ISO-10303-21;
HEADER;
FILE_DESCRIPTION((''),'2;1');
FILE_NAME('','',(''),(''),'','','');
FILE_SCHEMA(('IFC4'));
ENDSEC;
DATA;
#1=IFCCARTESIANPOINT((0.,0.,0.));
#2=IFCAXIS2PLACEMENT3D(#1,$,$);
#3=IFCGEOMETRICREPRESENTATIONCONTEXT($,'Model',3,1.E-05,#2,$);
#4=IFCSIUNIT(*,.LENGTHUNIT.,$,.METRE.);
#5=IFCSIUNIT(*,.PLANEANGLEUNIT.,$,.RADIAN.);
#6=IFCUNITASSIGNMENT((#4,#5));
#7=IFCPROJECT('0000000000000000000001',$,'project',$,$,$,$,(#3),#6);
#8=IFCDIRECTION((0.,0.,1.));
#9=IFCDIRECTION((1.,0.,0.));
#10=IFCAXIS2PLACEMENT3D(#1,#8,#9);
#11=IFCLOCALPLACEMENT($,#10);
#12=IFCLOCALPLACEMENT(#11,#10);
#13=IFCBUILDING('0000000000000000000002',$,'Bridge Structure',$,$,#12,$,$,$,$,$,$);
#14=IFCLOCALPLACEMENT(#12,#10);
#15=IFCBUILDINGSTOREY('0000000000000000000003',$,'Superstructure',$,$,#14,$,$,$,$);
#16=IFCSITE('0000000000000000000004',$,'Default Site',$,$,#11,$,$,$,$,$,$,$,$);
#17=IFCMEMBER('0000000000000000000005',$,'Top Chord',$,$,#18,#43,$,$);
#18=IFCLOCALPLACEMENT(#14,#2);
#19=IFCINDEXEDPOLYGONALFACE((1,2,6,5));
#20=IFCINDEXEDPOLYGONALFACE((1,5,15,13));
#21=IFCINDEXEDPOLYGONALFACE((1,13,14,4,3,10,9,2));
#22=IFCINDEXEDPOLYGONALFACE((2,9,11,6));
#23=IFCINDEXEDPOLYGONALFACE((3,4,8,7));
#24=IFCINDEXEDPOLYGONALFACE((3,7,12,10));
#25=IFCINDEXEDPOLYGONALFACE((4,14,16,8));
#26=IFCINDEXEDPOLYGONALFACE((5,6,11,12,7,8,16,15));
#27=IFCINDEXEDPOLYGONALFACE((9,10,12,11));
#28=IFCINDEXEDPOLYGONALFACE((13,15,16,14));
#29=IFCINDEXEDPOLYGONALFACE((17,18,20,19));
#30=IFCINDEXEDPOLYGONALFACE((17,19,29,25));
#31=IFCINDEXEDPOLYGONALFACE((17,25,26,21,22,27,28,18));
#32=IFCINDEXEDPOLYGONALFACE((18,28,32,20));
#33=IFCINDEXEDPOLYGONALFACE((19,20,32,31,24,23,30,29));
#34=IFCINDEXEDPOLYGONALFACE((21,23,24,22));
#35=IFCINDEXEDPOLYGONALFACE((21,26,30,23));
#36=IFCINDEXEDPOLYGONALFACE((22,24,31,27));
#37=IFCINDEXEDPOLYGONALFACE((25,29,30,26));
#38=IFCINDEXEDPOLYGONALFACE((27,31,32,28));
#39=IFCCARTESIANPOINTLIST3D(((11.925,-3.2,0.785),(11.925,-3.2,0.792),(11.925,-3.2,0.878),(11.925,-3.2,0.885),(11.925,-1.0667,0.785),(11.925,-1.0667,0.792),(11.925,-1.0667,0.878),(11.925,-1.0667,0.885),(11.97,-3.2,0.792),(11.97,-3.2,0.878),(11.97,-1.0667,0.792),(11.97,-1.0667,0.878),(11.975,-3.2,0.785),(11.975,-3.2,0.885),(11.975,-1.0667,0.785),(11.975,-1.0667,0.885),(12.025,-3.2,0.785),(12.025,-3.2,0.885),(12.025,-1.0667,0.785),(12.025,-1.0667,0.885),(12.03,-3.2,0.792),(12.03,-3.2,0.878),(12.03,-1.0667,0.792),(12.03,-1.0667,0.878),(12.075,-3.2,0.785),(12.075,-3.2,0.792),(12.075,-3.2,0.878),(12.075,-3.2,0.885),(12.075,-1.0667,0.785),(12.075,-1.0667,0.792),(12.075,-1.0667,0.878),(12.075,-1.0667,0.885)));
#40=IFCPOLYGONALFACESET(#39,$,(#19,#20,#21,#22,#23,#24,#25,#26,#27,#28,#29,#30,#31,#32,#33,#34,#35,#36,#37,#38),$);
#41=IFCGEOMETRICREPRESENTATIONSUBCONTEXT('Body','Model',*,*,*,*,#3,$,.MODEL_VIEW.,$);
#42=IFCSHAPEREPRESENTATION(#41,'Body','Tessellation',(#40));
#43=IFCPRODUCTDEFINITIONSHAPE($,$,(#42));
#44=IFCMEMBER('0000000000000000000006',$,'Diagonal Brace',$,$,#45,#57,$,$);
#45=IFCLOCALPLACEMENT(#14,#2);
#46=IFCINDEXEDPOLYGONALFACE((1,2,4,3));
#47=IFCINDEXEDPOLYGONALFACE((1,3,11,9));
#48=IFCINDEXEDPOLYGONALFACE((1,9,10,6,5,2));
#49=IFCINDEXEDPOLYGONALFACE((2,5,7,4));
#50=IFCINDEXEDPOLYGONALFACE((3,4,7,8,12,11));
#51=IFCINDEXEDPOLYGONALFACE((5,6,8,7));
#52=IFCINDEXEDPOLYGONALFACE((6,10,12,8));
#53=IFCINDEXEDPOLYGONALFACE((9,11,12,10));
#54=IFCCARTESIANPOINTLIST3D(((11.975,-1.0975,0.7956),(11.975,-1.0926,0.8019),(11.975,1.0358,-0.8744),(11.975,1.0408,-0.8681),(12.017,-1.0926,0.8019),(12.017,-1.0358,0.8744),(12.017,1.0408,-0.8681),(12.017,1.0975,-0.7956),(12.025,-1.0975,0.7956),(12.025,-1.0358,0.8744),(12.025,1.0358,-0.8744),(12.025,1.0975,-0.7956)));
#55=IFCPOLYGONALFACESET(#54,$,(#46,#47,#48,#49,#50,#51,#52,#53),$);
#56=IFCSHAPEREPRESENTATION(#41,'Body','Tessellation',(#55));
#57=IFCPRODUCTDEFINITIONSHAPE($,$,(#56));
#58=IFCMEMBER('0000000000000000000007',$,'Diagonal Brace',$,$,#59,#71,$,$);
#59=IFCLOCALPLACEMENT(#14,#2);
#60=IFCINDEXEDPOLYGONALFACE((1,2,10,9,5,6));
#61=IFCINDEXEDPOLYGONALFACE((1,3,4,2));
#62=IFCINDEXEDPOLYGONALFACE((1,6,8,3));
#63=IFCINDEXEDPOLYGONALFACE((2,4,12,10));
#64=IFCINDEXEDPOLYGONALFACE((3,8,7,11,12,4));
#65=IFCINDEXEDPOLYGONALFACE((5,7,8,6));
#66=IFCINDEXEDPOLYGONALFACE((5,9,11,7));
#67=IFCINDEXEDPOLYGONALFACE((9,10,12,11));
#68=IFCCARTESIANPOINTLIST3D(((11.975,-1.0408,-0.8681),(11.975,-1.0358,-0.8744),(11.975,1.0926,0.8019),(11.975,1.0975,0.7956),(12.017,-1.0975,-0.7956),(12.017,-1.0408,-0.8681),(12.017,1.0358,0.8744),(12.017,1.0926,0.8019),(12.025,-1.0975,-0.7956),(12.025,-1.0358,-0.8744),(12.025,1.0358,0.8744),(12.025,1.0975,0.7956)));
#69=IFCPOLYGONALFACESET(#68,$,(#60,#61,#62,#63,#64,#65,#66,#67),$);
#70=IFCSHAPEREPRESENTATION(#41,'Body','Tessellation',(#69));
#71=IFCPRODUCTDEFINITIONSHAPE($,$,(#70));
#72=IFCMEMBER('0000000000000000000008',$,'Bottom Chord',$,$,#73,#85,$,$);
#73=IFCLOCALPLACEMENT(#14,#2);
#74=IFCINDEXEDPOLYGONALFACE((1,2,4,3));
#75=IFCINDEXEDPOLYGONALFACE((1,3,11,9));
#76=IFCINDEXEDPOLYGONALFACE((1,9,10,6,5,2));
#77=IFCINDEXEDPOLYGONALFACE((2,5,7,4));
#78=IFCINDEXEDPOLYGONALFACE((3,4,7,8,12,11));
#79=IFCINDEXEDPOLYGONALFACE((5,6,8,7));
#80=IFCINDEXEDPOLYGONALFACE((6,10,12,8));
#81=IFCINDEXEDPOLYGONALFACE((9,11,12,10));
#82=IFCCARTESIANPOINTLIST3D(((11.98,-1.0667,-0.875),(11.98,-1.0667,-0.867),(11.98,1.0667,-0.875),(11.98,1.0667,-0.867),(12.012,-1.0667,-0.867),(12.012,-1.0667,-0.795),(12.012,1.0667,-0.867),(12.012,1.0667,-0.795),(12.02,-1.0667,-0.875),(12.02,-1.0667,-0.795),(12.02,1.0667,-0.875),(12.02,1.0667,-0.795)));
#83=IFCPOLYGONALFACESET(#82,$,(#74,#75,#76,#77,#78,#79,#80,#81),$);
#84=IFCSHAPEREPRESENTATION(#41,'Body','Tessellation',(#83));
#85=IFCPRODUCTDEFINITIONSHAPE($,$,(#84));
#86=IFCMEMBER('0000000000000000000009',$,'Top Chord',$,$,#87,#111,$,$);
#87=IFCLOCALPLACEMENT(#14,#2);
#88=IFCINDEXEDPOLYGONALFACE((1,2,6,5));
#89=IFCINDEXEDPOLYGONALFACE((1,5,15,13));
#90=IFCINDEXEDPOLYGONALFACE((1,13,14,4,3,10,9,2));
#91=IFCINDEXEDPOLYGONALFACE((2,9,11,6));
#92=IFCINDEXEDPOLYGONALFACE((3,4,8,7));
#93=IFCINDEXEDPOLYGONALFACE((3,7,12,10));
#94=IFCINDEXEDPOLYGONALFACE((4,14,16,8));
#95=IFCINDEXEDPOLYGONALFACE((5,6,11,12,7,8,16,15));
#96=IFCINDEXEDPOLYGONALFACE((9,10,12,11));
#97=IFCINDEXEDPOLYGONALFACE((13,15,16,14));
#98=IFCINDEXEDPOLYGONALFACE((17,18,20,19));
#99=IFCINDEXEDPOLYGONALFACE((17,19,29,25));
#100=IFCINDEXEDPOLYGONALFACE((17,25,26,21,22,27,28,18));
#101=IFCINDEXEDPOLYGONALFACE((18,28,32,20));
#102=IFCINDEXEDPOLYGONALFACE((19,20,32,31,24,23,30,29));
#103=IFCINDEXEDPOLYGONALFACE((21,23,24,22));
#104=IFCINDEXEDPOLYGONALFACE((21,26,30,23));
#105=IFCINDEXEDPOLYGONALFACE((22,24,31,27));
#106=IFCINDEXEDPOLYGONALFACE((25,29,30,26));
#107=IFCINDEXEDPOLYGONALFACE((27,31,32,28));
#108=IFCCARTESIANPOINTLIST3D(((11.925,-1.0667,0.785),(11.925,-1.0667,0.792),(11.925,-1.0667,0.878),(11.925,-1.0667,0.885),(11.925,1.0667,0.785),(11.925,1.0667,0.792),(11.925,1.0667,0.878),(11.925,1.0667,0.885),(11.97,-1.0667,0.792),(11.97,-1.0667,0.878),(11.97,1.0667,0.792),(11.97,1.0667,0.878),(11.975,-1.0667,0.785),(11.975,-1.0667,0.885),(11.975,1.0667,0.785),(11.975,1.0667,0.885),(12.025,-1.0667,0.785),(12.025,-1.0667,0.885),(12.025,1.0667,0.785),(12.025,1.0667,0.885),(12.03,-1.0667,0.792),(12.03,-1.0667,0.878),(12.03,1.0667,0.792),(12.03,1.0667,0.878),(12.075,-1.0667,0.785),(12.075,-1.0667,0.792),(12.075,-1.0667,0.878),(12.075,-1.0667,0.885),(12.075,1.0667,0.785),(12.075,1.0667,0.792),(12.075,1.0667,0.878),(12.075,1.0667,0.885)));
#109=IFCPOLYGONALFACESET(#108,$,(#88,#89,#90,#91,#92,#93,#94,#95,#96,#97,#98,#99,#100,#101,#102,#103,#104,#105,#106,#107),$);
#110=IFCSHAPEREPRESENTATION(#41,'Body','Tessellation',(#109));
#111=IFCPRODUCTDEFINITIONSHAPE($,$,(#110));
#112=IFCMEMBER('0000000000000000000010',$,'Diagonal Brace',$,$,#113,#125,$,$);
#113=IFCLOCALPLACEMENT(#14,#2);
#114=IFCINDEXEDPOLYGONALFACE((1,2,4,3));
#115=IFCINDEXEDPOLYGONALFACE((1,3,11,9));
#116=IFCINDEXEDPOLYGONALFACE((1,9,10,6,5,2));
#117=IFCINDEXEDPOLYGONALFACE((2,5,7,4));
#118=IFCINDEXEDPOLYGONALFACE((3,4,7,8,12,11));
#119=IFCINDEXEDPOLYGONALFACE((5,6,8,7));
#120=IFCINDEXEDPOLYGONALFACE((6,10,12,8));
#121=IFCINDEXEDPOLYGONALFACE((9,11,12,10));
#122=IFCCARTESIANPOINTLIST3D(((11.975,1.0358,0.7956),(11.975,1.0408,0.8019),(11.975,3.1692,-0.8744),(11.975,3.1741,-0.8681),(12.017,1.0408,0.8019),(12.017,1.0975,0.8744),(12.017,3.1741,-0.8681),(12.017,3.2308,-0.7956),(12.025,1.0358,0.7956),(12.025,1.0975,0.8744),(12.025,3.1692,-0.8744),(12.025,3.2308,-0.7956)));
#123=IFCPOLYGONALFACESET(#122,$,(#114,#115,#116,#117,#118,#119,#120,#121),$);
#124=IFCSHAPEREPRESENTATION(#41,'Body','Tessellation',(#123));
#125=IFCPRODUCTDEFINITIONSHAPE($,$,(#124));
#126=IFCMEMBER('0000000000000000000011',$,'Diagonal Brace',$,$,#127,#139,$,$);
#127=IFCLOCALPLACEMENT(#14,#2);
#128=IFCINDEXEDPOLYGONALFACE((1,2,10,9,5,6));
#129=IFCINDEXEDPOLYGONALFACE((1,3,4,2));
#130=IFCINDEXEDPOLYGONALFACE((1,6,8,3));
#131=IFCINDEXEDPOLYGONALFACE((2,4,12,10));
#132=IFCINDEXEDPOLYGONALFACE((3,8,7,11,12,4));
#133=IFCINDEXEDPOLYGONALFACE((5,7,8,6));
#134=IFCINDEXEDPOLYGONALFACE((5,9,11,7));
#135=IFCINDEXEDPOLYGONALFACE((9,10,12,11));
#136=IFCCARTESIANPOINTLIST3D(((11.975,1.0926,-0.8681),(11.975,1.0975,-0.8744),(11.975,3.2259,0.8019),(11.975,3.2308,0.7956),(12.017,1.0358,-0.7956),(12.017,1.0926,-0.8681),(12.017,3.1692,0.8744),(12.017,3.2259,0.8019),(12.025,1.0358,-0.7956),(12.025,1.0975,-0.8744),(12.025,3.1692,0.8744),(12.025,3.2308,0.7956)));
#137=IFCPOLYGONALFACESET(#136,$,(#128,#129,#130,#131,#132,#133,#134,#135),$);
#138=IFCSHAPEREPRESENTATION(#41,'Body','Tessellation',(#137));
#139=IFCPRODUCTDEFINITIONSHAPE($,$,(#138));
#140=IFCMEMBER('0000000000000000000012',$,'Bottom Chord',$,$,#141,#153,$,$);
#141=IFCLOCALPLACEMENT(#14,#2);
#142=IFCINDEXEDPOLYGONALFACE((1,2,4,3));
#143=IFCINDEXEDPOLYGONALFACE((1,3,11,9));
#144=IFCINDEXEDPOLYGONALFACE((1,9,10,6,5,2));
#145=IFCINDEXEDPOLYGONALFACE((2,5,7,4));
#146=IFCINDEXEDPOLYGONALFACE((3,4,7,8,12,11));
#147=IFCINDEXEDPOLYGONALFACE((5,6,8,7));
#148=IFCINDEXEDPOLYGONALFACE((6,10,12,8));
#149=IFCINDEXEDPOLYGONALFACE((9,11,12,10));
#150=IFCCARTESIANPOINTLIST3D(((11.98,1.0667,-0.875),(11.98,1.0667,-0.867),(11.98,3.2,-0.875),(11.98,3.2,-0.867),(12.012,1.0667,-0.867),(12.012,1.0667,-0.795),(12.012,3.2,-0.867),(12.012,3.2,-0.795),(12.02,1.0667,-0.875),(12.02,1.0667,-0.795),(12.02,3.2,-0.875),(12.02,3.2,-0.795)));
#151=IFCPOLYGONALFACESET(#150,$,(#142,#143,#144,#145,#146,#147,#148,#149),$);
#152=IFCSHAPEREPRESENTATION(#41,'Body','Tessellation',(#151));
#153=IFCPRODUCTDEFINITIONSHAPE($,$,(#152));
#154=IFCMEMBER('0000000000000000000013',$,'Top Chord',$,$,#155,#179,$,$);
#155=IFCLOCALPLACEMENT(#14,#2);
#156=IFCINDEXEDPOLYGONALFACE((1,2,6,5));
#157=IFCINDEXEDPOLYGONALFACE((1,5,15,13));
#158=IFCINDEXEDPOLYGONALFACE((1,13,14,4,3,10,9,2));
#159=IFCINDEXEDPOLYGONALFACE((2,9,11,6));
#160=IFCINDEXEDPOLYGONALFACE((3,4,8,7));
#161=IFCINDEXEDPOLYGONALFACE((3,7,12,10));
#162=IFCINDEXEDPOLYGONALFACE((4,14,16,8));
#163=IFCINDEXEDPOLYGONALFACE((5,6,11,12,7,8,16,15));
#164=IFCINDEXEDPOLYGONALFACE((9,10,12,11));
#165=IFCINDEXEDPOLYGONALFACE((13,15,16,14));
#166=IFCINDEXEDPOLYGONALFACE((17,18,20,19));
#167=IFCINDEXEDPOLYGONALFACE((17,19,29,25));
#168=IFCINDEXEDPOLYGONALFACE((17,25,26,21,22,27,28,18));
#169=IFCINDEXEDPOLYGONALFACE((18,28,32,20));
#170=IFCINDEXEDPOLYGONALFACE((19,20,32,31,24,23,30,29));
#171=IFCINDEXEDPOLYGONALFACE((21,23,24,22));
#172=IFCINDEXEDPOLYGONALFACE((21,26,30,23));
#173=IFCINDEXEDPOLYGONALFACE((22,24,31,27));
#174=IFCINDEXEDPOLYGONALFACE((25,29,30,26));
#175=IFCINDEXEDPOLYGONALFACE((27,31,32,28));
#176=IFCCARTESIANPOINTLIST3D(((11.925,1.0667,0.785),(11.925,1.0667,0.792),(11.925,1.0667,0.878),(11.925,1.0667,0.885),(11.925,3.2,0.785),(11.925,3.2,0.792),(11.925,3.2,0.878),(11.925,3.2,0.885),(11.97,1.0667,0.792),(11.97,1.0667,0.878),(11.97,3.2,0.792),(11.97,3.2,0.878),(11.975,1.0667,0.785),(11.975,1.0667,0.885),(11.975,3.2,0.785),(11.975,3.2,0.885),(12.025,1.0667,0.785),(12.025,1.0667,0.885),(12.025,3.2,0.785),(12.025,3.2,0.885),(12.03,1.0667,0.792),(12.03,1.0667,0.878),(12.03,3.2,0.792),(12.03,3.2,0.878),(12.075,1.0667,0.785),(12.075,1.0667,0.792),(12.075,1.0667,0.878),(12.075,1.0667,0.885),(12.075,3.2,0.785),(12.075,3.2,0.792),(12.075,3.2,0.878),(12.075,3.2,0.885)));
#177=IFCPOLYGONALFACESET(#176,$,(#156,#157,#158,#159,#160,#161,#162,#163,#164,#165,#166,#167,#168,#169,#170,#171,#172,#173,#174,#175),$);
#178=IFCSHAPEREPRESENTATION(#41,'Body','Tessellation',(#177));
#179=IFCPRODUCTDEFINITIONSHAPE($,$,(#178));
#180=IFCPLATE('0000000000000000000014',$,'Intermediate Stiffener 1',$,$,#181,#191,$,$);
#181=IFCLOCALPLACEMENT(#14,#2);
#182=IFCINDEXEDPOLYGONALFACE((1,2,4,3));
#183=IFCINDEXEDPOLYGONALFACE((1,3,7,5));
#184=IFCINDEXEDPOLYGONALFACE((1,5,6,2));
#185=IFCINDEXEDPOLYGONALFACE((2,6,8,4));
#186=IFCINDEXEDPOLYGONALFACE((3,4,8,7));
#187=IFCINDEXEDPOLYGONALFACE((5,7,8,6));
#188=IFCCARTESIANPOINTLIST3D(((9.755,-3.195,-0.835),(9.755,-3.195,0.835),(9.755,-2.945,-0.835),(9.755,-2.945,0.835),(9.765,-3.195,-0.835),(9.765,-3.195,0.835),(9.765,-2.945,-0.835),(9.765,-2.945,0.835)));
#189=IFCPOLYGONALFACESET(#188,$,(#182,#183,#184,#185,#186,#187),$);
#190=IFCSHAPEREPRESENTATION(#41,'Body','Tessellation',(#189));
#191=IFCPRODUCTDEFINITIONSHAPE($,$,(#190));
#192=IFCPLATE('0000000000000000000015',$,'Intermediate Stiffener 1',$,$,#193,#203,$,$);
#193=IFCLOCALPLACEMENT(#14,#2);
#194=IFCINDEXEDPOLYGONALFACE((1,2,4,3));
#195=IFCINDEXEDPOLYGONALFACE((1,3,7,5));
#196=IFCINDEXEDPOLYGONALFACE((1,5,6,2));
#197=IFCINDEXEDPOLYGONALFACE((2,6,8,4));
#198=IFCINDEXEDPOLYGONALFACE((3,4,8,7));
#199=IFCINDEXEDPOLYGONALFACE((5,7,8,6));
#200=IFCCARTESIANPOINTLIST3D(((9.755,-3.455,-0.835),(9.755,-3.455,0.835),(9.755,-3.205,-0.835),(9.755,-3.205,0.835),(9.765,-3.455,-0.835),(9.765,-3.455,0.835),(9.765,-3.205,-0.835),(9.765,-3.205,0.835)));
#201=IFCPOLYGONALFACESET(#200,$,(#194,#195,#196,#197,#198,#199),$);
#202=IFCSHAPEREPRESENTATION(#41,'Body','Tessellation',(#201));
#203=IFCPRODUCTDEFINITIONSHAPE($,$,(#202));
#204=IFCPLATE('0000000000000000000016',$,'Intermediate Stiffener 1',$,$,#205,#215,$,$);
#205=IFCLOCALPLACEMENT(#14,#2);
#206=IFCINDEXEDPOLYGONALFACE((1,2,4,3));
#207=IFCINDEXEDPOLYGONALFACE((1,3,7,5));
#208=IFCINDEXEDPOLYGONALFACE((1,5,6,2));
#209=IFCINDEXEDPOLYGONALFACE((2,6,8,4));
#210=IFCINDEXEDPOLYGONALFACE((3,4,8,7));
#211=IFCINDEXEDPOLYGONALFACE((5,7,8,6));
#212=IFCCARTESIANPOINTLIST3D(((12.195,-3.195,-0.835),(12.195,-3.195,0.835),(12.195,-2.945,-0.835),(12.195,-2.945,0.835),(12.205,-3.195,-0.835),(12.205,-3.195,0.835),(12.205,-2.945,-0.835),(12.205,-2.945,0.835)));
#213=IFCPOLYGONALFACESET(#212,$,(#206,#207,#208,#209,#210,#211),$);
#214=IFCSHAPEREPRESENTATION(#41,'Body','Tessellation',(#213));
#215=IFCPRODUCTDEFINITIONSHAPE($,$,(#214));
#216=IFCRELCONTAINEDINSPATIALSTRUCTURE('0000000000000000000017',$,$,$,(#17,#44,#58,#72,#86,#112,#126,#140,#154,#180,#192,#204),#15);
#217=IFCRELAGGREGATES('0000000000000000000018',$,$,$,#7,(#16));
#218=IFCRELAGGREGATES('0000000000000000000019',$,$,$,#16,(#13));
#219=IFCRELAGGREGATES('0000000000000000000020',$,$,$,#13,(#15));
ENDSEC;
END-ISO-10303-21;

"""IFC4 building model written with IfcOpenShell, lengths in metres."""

from ifc_helpers import new_model, si_unit, frame, origin, origin_with_axes, origin_2d_with_axis, place, context, subcontext, project, spatial, polyline, rectangle, l_section, outline, composite_profile, extrude, element, save


model = new_model("IFC4")

# Units and contexts
model_context = context("Model", 3, precision=1e-05, world=origin())
body_context = subcontext(model_context, "Body", "Model", "MODEL_VIEW")
ifc_project = project(units=[si_unit("LENGTHUNIT", "METRE"), si_unit("PLANEANGLEUNIT", "RADIAN")], contexts=[model_context])

# Site, building, storey
site_placement = place(None, origin_with_axes())
site = spatial("IfcSite", under=ifc_project, at=site_placement, Name="Default Site")
building_placement = place(site_placement, origin_with_axes())
building = spatial("IfcBuilding", under=site, at=building_placement, Name="Bridge Structure")
storey_placement = place(building_placement, origin_with_axes())
storey = spatial("IfcBuildingStorey", under=building, at=storey_placement, Name="Superstructure")

# Members
member_1_placement = place(storey_placement, frame((12.0, -3.2, 0.835), z_axis=(0.0, 1.0, 0.0), x_axis=(-1.0, 0.0, 0.0)))
element("IfcMember", 1, at=member_1_placement, inside=storey, Name="Top Chord", context=body_context, shape_type="SweptSolid", body=[
    extrude(composite_profile([outline(polyline([(-0.025, -0.05), (-0.025, 0.05), (-0.075, 0.05), (-0.075, 0.043), (-0.03, 0.043), (-0.03, -0.043), (-0.075, -0.043), (-0.075, -0.05), (-0.025, -0.05)])), outline(polyline([(0.025, -0.05), (0.075, -0.05), (0.075, -0.043), (0.03, -0.043), (0.03, 0.043), (0.075, 0.043), (0.075, 0.05), (0.025, 0.05), (0.025, -0.05)]))]), origin_with_axes(), (0.0, 0.0, 1.0), 2.1333),
])
for number, where, z_axis, x_axis, name in (
    (2, (12.0, -1.0667, 0.835), (0.0, 0.787427, -0.616408), (-1.0, 0.0, 0.0), "Diagonal Brace"),
    (3, (12.0, -1.0667, -0.835), (0.0, 0.787427, 0.616408), (-1.0, 0.0, 0.0), "Diagonal Brace"),
):
    element("IfcMember", number, at=place(storey_placement, frame(where, z_axis=z_axis, x_axis=x_axis)), inside=storey, Name=name, context=body_context, shape_type="SweptSolid", body=[
        extrude(l_section(Depth=0.1, Width=0.05, Thickness=0.008, at=origin_2d_with_axis()), origin_with_axes(), (0.0, 0.0, 1.0), 2.7092),
    ])
member_2_placement = place(storey_placement, frame((12.0, -1.0667, -0.835), z_axis=(0.0, 1.0, 0.0), x_axis=(-1.0, 0.0, 0.0)))
element("IfcMember", 4, at=member_2_placement, inside=storey, Name="Bottom Chord", context=body_context, shape_type="SweptSolid", body=[
    extrude(l_section(Depth=0.08, Width=0.04, Thickness=0.008, at=origin_2d_with_axis()), origin_with_axes(), (0.0, 0.0, 1.0), 2.1333),
])
member_3_placement = place(storey_placement, frame((12.0, -1.0667, 0.835), z_axis=(0.0, 1.0, 0.0), x_axis=(-1.0, 0.0, 0.0)))
element("IfcMember", 5, at=member_3_placement, inside=storey, Name="Top Chord", context=body_context, shape_type="SweptSolid", body=[
    extrude(composite_profile([outline(polyline([(-0.025, -0.05), (-0.025, 0.05), (-0.075, 0.05), (-0.075, 0.043), (-0.03, 0.043), (-0.03, -0.043), (-0.075, -0.043), (-0.075, -0.05), (-0.025, -0.05)])), outline(polyline([(0.025, -0.05), (0.075, -0.05), (0.075, -0.043), (0.03, -0.043), (0.03, 0.043), (0.075, 0.043), (0.075, 0.05), (0.025, 0.05), (0.025, -0.05)]))]), origin_with_axes(), (0.0, 0.0, 1.0), 2.1333),
])
for number, where, z_axis, x_axis, name in (
    (6, (12.0, 1.0667, 0.835), (0.0, 0.787427, -0.616408), (-1.0, 0.0, 0.0), "Diagonal Brace"),
    (7, (12.0, 1.0667, -0.835), (0.0, 0.787427, 0.616408), (-1.0, 0.0, 0.0), "Diagonal Brace"),
):
    element("IfcMember", number, at=place(storey_placement, frame(where, z_axis=z_axis, x_axis=x_axis)), inside=storey, Name=name, context=body_context, shape_type="SweptSolid", body=[
        extrude(l_section(Depth=0.1, Width=0.05, Thickness=0.008, at=origin_2d_with_axis()), origin_with_axes(), (0.0, 0.0, 1.0), 2.7092),
    ])
member_4_placement = place(storey_placement, frame((12.0, 1.0667, -0.835), z_axis=(0.0, 1.0, 0.0), x_axis=(-1.0, 0.0, 0.0)))
element("IfcMember", 8, at=member_4_placement, inside=storey, Name="Bottom Chord", context=body_context, shape_type="SweptSolid", body=[
    extrude(l_section(Depth=0.08, Width=0.04, Thickness=0.008, at=origin_2d_with_axis()), origin_with_axes(), (0.0, 0.0, 1.0), 2.1333),
])
member_5_placement = place(storey_placement, frame((12.0, 1.0667, 0.835), z_axis=(0.0, 1.0, 0.0), x_axis=(-1.0, 0.0, 0.0)))
element("IfcMember", 9, at=member_5_placement, inside=storey, Name="Top Chord", context=body_context, shape_type="SweptSolid", body=[
    extrude(composite_profile([outline(polyline([(-0.025, -0.05), (-0.025, 0.05), (-0.075, 0.05), (-0.075, 0.043), (-0.03, 0.043), (-0.03, -0.043), (-0.075, -0.043), (-0.075, -0.05), (-0.025, -0.05)])), outline(polyline([(0.025, -0.05), (0.075, -0.05), (0.075, -0.043), (0.03, -0.043), (0.03, 0.043), (0.075, 0.043), (0.075, 0.05), (0.025, 0.05), (0.025, -0.05)]))]), origin_with_axes(), (0.0, 0.0, 1.0), 2.1333),
])

# Plates
for number, where, z_axis, x_axis, name in (
    (10, (9.76, -3.07, -0.835), (0.0, 0.0, 1.0), (1.0, 0.0, 0.0), "Intermediate Stiffener 1"),
    (11, (9.76, -3.33, -0.835), (0.0, 0.0, 1.0), (1.0, 0.0, 0.0), "Intermediate Stiffener 1"),
    (12, (12.2, -3.07, -0.835), (0.0, 0.0, 1.0), (1.0, 0.0, 0.0), "Intermediate Stiffener 1"),
):
    element("IfcPlate", number, at=place(storey_placement, frame(where, z_axis=z_axis, x_axis=x_axis)), inside=storey, Name=name, context=body_context, shape_type="SweptSolid", body=[
        extrude(rectangle(XDim=0.01, YDim=0.25, at=origin_2d_with_axis()), origin_with_axes(), (0.0, 0.0, 1.0), 1.67),
    ])

save(model, "model.ifc")
